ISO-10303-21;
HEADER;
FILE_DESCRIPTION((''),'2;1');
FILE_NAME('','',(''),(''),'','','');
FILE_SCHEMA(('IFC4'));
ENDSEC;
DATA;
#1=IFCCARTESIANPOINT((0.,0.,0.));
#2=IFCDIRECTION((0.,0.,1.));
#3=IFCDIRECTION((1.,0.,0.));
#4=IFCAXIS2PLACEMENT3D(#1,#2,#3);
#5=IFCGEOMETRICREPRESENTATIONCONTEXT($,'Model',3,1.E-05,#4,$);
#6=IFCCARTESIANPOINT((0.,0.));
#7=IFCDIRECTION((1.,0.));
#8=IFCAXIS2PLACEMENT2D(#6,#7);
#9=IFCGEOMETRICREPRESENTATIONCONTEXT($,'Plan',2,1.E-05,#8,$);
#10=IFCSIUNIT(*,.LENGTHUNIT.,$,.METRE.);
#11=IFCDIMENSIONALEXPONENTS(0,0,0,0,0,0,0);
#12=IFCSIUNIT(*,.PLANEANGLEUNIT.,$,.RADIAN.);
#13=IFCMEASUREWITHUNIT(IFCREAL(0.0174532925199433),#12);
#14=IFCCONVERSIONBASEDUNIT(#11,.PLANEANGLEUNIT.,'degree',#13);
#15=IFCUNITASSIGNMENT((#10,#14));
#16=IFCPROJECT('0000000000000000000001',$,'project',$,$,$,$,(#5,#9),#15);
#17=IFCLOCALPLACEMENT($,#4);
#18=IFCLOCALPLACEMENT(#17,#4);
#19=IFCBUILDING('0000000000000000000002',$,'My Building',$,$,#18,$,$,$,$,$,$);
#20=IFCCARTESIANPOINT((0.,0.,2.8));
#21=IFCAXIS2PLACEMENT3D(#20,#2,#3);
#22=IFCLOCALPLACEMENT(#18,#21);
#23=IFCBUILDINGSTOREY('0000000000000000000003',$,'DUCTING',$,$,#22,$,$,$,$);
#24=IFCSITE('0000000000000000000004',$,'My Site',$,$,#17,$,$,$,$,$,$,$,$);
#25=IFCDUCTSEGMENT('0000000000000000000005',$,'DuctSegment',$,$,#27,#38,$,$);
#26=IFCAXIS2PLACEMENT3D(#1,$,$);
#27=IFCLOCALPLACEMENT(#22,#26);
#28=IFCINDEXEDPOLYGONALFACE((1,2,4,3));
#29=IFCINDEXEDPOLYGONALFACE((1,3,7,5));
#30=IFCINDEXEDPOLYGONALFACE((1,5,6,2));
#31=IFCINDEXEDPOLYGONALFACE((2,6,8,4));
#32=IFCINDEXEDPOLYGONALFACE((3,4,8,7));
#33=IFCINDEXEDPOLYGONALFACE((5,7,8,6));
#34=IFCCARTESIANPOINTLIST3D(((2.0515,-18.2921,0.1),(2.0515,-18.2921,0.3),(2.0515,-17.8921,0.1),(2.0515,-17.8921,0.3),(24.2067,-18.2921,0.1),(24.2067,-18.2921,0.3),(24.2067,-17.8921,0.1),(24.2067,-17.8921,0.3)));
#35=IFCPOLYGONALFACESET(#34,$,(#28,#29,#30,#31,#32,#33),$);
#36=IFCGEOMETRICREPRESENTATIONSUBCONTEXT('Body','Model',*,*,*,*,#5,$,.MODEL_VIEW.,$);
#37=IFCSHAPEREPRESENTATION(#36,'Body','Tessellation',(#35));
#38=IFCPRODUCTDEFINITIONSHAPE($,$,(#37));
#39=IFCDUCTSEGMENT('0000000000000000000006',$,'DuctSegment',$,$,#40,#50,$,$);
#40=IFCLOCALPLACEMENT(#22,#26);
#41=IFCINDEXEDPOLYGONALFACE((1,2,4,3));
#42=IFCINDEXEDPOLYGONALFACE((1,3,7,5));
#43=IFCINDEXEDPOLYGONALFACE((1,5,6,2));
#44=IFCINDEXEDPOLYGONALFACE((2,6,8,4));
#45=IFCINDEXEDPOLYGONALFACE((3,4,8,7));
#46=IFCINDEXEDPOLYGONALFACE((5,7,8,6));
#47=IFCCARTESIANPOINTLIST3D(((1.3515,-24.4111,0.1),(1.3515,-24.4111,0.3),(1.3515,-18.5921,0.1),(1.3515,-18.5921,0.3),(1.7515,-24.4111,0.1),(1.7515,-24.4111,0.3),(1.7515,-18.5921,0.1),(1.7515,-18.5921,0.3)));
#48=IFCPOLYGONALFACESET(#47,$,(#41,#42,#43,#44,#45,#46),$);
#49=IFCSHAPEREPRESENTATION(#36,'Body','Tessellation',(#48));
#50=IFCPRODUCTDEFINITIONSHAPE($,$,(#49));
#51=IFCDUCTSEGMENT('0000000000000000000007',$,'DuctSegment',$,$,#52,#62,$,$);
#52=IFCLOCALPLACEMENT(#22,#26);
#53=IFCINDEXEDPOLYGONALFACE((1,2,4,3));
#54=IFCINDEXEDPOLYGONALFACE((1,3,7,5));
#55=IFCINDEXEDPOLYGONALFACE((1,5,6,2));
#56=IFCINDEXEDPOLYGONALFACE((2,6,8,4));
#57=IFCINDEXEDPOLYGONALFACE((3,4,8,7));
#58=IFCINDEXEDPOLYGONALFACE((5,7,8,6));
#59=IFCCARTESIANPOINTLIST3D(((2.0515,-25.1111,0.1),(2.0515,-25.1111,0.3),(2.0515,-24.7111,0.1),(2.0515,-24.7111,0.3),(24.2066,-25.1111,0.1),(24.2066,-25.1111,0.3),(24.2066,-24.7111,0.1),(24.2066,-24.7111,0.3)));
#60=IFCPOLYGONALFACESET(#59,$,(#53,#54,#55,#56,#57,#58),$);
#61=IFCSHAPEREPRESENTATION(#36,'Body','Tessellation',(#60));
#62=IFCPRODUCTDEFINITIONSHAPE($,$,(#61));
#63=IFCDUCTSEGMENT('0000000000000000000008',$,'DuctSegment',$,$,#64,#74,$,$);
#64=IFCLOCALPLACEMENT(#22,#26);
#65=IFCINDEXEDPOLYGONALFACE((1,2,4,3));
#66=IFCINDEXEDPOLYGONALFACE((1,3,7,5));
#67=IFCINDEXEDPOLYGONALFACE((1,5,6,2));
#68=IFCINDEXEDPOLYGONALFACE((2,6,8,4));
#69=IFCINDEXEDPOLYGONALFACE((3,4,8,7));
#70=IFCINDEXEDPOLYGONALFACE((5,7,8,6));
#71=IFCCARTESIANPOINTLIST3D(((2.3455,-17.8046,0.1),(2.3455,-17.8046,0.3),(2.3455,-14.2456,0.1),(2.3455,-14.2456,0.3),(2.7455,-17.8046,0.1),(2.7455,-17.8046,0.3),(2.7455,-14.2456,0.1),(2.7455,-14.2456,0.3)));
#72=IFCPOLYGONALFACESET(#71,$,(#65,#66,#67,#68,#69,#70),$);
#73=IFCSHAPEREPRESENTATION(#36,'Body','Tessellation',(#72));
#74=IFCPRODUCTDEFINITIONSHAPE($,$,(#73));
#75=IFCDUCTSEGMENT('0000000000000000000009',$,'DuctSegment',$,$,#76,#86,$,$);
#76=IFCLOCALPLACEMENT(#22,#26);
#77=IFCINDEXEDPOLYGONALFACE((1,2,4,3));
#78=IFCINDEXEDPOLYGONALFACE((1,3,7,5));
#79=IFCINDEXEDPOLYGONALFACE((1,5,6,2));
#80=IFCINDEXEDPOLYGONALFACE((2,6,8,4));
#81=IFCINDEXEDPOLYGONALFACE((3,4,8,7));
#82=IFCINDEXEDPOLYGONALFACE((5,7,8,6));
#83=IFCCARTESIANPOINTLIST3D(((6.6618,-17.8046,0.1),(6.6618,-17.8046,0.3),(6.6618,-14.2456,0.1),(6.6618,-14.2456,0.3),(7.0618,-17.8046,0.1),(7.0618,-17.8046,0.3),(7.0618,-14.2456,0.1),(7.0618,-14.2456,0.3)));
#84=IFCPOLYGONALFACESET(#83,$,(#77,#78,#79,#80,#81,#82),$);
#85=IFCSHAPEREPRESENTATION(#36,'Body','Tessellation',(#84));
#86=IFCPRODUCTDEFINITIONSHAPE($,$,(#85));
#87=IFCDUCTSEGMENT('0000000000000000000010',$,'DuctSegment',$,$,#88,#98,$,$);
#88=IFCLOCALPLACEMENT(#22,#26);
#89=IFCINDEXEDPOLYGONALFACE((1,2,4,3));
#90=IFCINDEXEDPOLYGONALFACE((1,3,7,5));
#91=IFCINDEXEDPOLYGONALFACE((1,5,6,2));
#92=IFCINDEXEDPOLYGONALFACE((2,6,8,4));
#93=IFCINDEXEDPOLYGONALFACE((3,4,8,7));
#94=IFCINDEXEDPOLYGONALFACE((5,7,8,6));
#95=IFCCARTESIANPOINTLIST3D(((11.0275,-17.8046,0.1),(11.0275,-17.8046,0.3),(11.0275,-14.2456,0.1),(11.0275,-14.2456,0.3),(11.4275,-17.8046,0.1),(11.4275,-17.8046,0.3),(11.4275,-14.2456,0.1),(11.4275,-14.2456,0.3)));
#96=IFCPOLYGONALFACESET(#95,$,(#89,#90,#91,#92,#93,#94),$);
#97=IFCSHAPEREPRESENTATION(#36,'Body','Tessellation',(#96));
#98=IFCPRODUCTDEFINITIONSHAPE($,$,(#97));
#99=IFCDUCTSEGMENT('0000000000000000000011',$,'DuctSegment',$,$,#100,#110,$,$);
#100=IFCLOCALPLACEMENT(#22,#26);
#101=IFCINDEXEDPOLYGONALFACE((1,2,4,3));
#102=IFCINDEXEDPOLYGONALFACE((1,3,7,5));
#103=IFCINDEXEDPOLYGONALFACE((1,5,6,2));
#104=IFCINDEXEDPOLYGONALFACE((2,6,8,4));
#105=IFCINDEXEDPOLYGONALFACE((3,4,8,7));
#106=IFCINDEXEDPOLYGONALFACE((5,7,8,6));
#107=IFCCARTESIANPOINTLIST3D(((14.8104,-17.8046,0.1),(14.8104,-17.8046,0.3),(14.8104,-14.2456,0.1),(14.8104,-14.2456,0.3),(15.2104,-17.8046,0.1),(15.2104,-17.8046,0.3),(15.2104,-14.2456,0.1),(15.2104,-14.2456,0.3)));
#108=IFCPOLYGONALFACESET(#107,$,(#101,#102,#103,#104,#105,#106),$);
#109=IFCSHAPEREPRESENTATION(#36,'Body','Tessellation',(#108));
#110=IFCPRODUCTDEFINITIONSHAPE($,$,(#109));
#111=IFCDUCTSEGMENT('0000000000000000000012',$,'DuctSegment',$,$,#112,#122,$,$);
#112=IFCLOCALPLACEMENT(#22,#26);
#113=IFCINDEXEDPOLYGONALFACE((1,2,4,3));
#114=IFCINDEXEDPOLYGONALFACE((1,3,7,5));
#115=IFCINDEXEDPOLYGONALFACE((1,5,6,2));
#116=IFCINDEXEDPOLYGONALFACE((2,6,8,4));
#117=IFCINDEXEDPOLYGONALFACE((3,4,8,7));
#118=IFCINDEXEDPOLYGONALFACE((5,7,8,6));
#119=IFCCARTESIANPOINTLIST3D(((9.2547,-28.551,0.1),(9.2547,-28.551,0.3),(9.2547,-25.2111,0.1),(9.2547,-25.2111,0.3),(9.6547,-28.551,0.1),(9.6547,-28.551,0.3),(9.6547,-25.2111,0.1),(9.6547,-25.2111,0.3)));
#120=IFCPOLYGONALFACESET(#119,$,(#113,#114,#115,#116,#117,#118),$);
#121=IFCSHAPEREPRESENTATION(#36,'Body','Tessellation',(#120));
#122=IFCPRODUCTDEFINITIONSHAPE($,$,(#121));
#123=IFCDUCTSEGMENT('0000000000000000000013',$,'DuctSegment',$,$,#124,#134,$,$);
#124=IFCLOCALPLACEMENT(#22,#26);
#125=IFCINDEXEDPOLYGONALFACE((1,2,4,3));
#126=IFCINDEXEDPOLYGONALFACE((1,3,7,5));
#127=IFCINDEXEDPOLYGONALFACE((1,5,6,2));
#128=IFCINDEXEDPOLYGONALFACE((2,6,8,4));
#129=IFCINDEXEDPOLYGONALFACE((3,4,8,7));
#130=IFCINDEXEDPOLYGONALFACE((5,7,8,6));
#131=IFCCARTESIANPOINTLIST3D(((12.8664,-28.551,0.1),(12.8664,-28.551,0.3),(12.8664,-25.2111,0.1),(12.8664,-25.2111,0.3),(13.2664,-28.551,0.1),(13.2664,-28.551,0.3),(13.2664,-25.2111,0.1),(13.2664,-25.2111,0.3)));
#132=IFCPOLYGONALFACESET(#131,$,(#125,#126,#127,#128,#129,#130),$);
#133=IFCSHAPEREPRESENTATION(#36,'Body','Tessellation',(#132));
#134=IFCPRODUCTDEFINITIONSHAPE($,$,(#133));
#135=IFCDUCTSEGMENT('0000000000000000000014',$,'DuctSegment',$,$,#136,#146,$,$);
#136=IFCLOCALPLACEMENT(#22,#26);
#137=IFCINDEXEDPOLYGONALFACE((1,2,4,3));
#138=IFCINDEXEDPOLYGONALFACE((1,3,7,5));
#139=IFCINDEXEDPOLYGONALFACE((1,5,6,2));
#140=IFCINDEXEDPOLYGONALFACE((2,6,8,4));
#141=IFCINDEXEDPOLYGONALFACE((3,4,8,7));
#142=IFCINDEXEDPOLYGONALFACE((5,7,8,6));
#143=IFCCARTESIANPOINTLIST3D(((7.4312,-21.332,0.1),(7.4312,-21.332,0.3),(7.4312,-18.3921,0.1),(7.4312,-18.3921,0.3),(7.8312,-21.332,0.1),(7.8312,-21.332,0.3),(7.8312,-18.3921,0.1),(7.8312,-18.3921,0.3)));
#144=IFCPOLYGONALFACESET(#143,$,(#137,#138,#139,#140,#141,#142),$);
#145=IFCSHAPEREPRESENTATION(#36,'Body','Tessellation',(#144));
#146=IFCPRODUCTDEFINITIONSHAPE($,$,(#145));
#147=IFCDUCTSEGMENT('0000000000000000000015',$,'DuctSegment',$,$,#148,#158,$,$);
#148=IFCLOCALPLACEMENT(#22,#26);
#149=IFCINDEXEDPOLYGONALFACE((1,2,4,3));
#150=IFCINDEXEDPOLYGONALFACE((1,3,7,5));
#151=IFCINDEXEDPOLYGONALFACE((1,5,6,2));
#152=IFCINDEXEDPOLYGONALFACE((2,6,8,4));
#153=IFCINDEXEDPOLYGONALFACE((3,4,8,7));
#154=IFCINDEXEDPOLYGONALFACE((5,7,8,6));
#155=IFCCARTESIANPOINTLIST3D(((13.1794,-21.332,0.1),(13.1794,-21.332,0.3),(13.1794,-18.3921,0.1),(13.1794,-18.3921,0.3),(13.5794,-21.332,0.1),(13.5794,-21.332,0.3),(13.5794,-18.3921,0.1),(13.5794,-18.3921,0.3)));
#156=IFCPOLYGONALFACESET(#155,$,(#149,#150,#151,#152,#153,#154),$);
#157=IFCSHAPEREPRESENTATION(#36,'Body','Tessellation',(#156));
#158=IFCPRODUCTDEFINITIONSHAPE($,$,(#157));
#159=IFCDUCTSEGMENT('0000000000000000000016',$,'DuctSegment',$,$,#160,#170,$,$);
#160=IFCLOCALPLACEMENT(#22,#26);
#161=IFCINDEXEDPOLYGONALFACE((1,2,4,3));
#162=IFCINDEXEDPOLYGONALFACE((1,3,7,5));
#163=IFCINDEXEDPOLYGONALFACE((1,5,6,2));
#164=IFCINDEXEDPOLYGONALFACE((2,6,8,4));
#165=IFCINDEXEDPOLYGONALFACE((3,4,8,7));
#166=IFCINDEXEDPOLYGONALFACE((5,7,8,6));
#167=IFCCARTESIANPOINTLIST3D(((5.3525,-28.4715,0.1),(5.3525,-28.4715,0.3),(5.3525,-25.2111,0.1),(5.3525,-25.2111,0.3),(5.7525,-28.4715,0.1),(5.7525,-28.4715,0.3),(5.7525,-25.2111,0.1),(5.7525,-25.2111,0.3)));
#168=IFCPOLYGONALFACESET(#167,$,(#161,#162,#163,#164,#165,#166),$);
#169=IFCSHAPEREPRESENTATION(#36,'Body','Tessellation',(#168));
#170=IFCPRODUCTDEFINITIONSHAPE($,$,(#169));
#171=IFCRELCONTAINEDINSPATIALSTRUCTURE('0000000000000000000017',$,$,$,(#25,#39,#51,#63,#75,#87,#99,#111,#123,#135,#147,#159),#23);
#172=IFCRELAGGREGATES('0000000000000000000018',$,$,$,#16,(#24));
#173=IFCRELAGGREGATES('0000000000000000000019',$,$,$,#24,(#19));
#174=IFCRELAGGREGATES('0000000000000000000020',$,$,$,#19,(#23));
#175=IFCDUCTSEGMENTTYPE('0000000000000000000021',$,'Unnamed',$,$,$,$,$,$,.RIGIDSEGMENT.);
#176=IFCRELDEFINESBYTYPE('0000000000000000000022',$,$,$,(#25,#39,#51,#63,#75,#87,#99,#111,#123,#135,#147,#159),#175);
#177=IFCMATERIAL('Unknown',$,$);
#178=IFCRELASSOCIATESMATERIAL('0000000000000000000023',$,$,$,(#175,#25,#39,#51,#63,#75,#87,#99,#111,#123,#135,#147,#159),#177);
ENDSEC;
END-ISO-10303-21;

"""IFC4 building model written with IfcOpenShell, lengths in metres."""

from ifc_helpers import new_model, entity, si_unit, converted_unit, frame, origin_with_axes, origin_2d_with_axis, place, context, subcontext, project, spatial, rectangle, extrude, material, material_profile, profile_set, profile_usage, type_object, element, save


model = new_model("IFC4")

# Units and contexts
model_context = context("Model", 3, precision=1e-05, world=origin_with_axes())
plan_context = context("Plan", 2, precision=1e-05, world=origin_2d_with_axis())
body_context = subcontext(model_context, "Body", "Model", "MODEL_VIEW")
ifc_project = project(units=[si_unit("LENGTHUNIT", "METRE"), converted_unit("PLANEANGLEUNIT", "degree", entity("IfcReal", 0.0174532925199433), si_unit("PLANEANGLEUNIT", "RADIAN"), dimensions=[0, 0, 0, 0, 0, 0, 0])], contexts=[model_context, plan_context])

# Site, building, storey
site_placement = place(None, origin_with_axes())
site = spatial("IfcSite", under=ifc_project, at=site_placement, Name="My Site")
building_placement = place(site_placement, origin_with_axes())
building = spatial("IfcBuilding", under=site, at=building_placement, Name="My Building")
storey_placement = place(building_placement, frame((0.0, 0.0, 2.8), z_axis=(0.0, 0.0, 1.0), x_axis=(1.0, 0.0, 0.0)))
storey = spatial("IfcBuildingStorey", under=building, at=storey_placement, Name="DUCTING")

# Duct segments
ifc_material = material(Name="Unknown")
ifc_material_profile_1 = material_profile(ifc_material, rectangle(XDim=0.4, YDim=0.2))
ifc_profile_set_1 = profile_set([ifc_material_profile_1])
ifc_profile_usage_1 = profile_usage(ifc_profile_set_1, cardinal=5)
duct_segment_type = type_object("IfcDuctSegmentType", Name="Unnamed", PredefinedType="RIGIDSEGMENT", material=ifc_profile_set_1)
duct_segment_1_placement = place(storey_placement, frame((2.0515, -18.0921, 0.2), z_axis=(1.0, 0.0, 0.0), x_axis=(0.0, 1.0, 0.0)))
element("IfcDuctSegment", 1, at=duct_segment_1_placement, inside=storey, type_object=duct_segment_type, material=ifc_profile_usage_1, Name="DuctSegment", context=body_context, shape_type="SweptSolid", body=[
    extrude(rectangle(XDim=0.4, YDim=0.2), origin_with_axes(), (0.0, 0.0, 1.0), 22.1552),
])
ifc_profile_usage_2 = profile_usage(ifc_profile_set_1, cardinal=5)
duct_segment_2_placement = place(storey_placement, frame((1.5515, -18.5921, 0.2), z_axis=(0.0, -1.0, 0.0), x_axis=(1.0, 0.0, 0.0)))
element("IfcDuctSegment", 2, at=duct_segment_2_placement, inside=storey, type_object=duct_segment_type, material=ifc_profile_usage_2, Name="DuctSegment", context=body_context, shape_type="SweptSolid", body=[
    extrude(rectangle(XDim=0.4, YDim=0.2), origin_with_axes(), (0.0, 0.0, 1.0), 5.819),
])
ifc_profile_usage_3 = profile_usage(ifc_profile_set_1, cardinal=5)
duct_segment_3_placement = place(storey_placement, frame((2.0515, -24.9111, 0.2), z_axis=(1.0, 0.0, 0.0), x_axis=(0.0, 1.0, 0.0)))
element("IfcDuctSegment", 3, at=duct_segment_3_placement, inside=storey, type_object=duct_segment_type, material=ifc_profile_usage_3, Name="DuctSegment", context=body_context, shape_type="SweptSolid", body=[
    extrude(rectangle(XDim=0.4, YDim=0.2), origin_with_axes(), (0.0, 0.0, 1.0), 22.1551),
])
ifc_profile_usage_4 = profile_usage(ifc_profile_set_1, cardinal=5)
duct_segment_4_placement = place(storey_placement, frame((2.5455, -17.8046, 0.2), z_axis=(0.0, 1.0, 0.0), x_axis=(-1.0, 0.0, 0.0)))
element("IfcDuctSegment", 4, at=duct_segment_4_placement, inside=storey, type_object=duct_segment_type, material=ifc_profile_usage_4, Name="DuctSegment", context=body_context, shape_type="SweptSolid", body=[
    extrude(rectangle(XDim=0.4, YDim=0.2), origin_with_axes(), (0.0, 0.0, 1.0), 3.5591),
])
ifc_profile_usage_5 = profile_usage(ifc_profile_set_1, cardinal=5)
duct_segment_5_placement = place(storey_placement, frame((6.8618, -17.8046, 0.2), z_axis=(0.0, 1.0, 0.0), x_axis=(-1.0, 0.0, 0.0)))
element("IfcDuctSegment", 5, at=duct_segment_5_placement, inside=storey, type_object=duct_segment_type, material=ifc_profile_usage_5, Name="DuctSegment", context=body_context, shape_type="SweptSolid", body=[
    extrude(rectangle(XDim=0.4, YDim=0.2), origin_with_axes(), (0.0, 0.0, 1.0), 3.5591),
])
ifc_profile_usage_6 = profile_usage(ifc_profile_set_1, cardinal=5)
duct_segment_6_placement = place(storey_placement, frame((11.2275, -17.8046, 0.2), z_axis=(0.0, 1.0, 0.0), x_axis=(-1.0, 0.0, 0.0)))
element("IfcDuctSegment", 6, at=duct_segment_6_placement, inside=storey, type_object=duct_segment_type, material=ifc_profile_usage_6, Name="DuctSegment", context=body_context, shape_type="SweptSolid", body=[
    extrude(rectangle(XDim=0.4, YDim=0.2), origin_with_axes(), (0.0, 0.0, 1.0), 3.5591),
])
ifc_profile_usage_7 = profile_usage(ifc_profile_set_1, cardinal=5)
duct_segment_7_placement = place(storey_placement, frame((15.0104, -17.8046, 0.2), z_axis=(0.0, 1.0, 0.0), x_axis=(-1.0, 0.0, 0.0)))
element("IfcDuctSegment", 7, at=duct_segment_7_placement, inside=storey, type_object=duct_segment_type, material=ifc_profile_usage_7, Name="DuctSegment", context=body_context, shape_type="SweptSolid", body=[
    extrude(rectangle(XDim=0.4, YDim=0.2), origin_with_axes(), (0.0, 0.0, 1.0), 3.5591),
])
ifc_profile_usage_8 = profile_usage(ifc_profile_set_1, cardinal=5)
duct_segment_8_placement = place(storey_placement, frame((9.4547, -25.2111, 0.2), z_axis=(0.0, -1.0, 0.0), x_axis=(1.0, 0.0, 0.0)))
element("IfcDuctSegment", 8, at=duct_segment_8_placement, inside=storey, type_object=duct_segment_type, material=ifc_profile_usage_8, Name="DuctSegment", context=body_context, shape_type="SweptSolid", body=[
    extrude(rectangle(XDim=0.4, YDim=0.2), origin_with_axes(), (0.0, 0.0, 1.0), 3.3399),
])
ifc_profile_usage_9 = profile_usage(ifc_profile_set_1, cardinal=5)
duct_segment_9_placement = place(storey_placement, frame((13.0664, -25.2111, 0.2), z_axis=(0.0, -1.0, 0.0), x_axis=(1.0, 0.0, 0.0)))
element("IfcDuctSegment", 9, at=duct_segment_9_placement, inside=storey, type_object=duct_segment_type, material=ifc_profile_usage_9, Name="DuctSegment", context=body_context, shape_type="SweptSolid", body=[
    extrude(rectangle(XDim=0.4, YDim=0.2), origin_with_axes(), (0.0, 0.0, 1.0), 3.3399),
])
ifc_profile_usage_10 = profile_usage(ifc_profile_set_1, cardinal=5)
duct_segment_10_placement = place(storey_placement, frame((7.6312, -18.3921, 0.2), z_axis=(0.0, -1.0, 0.0), x_axis=(1.0, 0.0, 0.0)))
element("IfcDuctSegment", 10, at=duct_segment_10_placement, inside=storey, type_object=duct_segment_type, material=ifc_profile_usage_10, Name="DuctSegment", context=body_context, shape_type="SweptSolid", body=[
    extrude(rectangle(XDim=0.4, YDim=0.2), origin_with_axes(), (0.0, 0.0, 1.0), 2.9399),
])
ifc_profile_usage_11 = profile_usage(ifc_profile_set_1, cardinal=5)
duct_segment_11_placement = place(storey_placement, frame((13.3794, -18.3921, 0.2), z_axis=(0.0, -1.0, 0.0), x_axis=(1.0, 0.0, 0.0)))
element("IfcDuctSegment", 11, at=duct_segment_11_placement, inside=storey, type_object=duct_segment_type, material=ifc_profile_usage_11, Name="DuctSegment", context=body_context, shape_type="SweptSolid", body=[
    extrude(rectangle(XDim=0.4, YDim=0.2), origin_with_axes(), (0.0, 0.0, 1.0), 2.9399),
])
ifc_profile_usage_12 = profile_usage(ifc_profile_set_1, cardinal=5)
duct_segment_12_placement = place(storey_placement, frame((5.5525, -25.2111, 0.2), z_axis=(0.0, -1.0, 0.0), x_axis=(1.0, 0.0, 0.0)))
element("IfcDuctSegment", 12, at=duct_segment_12_placement, inside=storey, type_object=duct_segment_type, material=ifc_profile_usage_12, Name="DuctSegment", context=body_context, shape_type="SweptSolid", body=[
    extrude(rectangle(XDim=0.4, YDim=0.2), origin_with_axes(), (0.0, 0.0, 1.0), 3.2604),
])

save(model, "model.ifc")
